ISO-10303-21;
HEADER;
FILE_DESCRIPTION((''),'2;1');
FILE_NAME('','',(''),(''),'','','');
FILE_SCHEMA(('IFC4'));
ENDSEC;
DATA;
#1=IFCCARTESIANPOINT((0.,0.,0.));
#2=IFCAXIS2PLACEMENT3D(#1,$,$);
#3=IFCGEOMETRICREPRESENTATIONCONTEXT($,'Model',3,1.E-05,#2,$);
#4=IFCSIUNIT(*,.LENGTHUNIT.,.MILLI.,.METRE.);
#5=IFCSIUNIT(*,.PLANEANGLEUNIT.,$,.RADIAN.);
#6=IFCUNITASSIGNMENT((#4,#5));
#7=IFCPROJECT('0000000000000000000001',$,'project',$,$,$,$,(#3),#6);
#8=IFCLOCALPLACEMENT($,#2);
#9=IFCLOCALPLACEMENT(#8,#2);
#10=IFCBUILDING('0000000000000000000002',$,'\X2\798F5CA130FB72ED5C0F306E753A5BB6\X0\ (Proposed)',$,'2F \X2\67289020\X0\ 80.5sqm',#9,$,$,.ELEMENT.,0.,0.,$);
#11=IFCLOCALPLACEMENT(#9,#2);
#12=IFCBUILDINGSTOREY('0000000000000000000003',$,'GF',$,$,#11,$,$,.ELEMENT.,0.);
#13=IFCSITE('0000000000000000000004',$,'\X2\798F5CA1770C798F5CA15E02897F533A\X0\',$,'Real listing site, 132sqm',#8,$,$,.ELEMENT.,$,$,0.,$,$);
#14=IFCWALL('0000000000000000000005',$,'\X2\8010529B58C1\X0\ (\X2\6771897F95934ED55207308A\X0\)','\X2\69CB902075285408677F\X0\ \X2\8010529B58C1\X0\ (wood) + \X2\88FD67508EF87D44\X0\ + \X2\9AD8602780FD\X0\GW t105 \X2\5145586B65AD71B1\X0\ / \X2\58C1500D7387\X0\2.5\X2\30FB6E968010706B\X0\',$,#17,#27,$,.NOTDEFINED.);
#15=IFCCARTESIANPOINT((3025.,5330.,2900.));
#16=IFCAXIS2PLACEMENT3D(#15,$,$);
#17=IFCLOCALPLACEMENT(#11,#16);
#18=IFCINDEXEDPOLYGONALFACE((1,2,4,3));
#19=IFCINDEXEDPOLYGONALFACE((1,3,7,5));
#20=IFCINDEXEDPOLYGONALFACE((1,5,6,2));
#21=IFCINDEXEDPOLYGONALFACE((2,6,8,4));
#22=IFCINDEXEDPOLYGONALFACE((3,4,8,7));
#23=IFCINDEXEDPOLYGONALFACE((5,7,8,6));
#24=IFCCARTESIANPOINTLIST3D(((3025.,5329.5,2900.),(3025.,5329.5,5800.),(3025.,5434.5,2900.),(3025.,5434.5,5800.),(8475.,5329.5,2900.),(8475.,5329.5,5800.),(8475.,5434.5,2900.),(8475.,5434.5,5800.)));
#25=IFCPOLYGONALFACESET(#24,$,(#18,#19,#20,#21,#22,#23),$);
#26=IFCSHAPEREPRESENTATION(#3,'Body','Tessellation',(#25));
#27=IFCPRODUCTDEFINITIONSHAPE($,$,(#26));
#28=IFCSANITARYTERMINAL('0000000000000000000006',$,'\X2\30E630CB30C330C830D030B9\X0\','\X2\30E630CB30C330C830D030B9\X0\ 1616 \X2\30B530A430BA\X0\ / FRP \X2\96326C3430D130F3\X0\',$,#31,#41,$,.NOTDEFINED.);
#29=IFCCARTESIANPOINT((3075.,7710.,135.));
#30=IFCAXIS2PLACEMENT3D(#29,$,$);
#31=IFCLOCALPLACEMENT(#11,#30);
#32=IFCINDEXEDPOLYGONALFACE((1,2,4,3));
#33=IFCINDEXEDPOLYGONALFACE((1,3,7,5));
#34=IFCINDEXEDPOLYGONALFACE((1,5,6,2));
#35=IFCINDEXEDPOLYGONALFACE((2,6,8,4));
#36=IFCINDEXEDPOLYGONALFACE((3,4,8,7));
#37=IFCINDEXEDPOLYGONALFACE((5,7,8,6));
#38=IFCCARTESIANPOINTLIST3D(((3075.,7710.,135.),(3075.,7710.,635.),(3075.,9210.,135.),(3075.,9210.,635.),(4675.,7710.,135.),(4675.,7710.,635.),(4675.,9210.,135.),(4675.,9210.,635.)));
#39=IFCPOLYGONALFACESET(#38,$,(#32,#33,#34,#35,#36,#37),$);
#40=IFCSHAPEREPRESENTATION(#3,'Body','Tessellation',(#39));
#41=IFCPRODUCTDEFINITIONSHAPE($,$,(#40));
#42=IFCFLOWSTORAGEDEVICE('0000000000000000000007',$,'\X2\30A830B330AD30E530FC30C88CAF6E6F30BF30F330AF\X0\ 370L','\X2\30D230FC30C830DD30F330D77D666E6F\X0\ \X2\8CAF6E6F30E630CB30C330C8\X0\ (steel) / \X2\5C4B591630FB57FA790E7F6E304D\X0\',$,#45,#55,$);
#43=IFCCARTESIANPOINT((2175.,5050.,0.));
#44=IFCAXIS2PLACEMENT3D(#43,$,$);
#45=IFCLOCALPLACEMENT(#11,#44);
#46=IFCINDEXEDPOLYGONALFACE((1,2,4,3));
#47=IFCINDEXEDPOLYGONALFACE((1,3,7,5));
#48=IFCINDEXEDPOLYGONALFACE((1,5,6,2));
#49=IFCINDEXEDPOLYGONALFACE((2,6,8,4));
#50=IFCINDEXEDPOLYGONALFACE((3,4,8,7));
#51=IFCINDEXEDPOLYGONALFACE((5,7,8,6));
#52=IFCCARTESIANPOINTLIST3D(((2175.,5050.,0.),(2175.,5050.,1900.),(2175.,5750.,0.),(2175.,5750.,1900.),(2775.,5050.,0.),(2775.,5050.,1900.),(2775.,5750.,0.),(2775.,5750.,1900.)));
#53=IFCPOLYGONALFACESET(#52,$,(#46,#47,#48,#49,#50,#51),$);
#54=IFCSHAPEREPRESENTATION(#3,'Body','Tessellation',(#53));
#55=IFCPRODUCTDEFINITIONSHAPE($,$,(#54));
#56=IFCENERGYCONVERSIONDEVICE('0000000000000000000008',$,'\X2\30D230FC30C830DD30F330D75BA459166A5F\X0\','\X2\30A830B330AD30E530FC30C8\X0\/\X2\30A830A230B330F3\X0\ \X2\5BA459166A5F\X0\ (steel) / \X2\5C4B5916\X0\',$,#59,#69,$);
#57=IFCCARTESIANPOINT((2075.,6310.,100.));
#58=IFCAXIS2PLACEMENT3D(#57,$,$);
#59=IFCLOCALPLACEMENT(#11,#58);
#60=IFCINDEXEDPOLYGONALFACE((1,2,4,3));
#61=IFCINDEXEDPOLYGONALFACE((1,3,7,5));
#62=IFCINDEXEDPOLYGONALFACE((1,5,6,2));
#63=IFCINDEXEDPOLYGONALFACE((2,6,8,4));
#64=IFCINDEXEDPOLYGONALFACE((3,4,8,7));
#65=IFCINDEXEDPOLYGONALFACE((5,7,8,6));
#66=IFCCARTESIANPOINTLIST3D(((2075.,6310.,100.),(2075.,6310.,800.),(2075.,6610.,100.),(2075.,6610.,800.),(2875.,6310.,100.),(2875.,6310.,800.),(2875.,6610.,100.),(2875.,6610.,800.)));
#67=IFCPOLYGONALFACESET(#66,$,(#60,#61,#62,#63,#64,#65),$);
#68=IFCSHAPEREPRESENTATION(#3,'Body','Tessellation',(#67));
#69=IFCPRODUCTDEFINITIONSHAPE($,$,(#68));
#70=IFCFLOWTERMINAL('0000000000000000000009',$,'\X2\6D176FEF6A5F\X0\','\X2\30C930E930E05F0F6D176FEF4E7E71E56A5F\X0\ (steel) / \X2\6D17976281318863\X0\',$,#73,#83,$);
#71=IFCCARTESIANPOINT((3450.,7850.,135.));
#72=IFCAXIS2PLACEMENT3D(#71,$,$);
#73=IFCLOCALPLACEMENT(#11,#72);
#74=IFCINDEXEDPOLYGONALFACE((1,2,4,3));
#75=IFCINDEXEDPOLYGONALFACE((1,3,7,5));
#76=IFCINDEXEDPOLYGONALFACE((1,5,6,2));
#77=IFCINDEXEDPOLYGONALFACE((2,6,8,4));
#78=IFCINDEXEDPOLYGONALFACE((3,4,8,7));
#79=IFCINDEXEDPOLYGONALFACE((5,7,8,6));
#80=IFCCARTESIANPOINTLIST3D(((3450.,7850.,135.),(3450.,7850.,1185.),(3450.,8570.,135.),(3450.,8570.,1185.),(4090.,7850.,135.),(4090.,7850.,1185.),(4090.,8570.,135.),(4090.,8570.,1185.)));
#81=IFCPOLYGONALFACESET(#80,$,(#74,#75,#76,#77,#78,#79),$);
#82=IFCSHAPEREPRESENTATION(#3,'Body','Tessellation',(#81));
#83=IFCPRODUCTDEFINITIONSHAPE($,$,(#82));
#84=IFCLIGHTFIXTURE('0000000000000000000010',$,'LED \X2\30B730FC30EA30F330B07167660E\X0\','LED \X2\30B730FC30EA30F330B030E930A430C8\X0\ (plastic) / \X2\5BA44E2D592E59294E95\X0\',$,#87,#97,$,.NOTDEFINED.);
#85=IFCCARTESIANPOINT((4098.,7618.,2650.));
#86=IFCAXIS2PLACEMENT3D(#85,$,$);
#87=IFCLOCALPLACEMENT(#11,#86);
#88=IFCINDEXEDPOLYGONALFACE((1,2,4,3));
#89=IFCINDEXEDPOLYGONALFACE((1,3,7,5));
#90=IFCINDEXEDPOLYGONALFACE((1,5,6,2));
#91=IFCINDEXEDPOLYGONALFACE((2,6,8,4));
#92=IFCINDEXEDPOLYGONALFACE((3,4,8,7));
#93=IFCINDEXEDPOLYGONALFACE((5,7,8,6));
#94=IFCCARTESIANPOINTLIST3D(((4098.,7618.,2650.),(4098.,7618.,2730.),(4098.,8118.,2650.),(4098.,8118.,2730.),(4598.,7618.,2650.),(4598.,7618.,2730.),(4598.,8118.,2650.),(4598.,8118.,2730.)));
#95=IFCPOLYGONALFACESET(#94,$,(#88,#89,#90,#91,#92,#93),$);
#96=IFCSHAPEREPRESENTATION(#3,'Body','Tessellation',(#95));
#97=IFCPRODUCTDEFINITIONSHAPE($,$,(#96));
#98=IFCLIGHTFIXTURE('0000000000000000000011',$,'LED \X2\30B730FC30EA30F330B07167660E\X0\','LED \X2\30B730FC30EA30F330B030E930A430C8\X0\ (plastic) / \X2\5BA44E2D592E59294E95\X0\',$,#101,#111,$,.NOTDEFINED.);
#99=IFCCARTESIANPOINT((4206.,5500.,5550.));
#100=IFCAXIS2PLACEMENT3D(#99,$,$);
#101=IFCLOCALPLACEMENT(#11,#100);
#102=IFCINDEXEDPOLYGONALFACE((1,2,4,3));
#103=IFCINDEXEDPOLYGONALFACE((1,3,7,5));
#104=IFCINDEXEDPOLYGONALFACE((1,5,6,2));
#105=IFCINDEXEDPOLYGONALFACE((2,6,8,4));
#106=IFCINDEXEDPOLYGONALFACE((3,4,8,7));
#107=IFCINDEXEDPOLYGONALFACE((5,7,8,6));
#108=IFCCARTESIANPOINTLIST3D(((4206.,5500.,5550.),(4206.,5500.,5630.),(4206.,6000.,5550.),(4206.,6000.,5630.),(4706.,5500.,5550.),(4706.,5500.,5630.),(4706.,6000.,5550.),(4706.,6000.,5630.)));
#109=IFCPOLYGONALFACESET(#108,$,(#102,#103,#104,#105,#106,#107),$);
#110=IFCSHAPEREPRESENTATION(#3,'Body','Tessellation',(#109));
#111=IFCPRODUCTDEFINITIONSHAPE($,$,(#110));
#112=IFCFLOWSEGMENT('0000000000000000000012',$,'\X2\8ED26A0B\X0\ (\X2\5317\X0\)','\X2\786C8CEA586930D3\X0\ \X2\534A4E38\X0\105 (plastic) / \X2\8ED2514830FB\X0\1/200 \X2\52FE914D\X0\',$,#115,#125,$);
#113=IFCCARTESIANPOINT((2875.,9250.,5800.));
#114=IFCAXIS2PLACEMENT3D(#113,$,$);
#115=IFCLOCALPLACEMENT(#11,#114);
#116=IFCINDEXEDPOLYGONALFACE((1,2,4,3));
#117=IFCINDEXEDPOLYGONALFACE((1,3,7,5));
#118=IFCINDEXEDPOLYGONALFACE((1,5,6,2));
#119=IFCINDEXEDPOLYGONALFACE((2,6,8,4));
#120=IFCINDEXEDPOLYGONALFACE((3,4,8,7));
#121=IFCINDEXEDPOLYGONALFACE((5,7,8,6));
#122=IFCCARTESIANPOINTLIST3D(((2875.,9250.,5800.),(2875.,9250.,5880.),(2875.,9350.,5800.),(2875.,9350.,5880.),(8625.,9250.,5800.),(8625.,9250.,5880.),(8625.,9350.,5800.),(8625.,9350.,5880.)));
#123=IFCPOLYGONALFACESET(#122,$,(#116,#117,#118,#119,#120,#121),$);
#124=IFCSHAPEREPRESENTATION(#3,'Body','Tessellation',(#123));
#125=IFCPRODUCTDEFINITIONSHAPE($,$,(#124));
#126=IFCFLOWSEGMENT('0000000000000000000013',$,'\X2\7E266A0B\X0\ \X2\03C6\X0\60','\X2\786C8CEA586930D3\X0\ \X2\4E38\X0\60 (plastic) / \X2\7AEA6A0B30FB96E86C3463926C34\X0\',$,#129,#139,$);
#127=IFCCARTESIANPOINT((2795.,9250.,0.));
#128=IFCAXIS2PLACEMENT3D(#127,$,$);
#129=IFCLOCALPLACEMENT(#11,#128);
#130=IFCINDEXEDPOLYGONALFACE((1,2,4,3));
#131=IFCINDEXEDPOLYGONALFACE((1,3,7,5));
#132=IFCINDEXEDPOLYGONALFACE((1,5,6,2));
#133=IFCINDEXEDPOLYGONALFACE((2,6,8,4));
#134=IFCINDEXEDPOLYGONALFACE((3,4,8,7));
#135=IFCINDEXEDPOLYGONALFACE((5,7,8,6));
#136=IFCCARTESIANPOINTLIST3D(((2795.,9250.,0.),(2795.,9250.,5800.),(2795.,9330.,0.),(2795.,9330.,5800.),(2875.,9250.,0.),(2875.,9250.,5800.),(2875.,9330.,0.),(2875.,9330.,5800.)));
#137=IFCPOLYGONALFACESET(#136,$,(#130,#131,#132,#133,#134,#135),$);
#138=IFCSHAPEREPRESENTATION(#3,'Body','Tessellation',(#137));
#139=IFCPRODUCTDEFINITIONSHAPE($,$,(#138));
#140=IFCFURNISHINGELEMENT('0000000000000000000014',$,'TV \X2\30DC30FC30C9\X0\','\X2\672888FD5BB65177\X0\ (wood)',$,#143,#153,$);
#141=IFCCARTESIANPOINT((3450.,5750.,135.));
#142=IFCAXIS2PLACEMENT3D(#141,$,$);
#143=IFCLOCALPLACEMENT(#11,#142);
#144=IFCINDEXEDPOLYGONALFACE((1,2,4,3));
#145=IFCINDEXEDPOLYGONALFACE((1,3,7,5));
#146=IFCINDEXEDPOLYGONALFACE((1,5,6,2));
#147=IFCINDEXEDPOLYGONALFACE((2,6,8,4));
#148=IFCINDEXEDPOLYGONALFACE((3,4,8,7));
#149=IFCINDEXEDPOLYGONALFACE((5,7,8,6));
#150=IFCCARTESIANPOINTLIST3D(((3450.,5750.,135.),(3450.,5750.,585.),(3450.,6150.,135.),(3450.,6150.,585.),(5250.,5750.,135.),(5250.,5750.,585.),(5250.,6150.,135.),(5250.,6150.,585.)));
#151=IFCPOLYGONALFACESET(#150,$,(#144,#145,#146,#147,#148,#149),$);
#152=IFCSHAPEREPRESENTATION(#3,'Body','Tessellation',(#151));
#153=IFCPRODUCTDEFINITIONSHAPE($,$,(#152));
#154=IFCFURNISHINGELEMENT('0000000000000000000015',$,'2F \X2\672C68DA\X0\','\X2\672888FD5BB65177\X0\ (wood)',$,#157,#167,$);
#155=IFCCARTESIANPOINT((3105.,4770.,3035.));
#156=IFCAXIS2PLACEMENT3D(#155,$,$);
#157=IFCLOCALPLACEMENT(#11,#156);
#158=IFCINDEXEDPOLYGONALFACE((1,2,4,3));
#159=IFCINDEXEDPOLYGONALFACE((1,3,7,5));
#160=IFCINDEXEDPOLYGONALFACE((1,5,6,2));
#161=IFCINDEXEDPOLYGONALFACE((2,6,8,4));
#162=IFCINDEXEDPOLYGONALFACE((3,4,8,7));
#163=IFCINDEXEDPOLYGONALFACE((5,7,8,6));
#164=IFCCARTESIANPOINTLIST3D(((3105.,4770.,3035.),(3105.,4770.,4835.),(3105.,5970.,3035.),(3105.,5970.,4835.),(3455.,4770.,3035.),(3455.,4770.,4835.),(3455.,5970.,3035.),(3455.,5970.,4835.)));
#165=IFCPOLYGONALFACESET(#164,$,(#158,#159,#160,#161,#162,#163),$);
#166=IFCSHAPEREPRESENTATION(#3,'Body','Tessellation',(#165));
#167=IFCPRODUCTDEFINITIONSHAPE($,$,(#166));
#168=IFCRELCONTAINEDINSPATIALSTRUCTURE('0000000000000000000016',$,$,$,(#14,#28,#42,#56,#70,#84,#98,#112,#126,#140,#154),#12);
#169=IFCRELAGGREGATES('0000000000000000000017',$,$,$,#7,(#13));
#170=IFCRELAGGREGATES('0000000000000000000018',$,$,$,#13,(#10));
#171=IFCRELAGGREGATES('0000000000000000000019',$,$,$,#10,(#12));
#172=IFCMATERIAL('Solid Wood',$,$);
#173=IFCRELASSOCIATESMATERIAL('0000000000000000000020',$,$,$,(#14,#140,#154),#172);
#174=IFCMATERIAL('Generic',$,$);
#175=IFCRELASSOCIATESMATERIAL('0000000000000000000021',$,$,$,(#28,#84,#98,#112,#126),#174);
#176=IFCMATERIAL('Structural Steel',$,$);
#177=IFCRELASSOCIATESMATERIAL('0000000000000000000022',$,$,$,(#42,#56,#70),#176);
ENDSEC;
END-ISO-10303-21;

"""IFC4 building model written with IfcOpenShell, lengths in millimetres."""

from ifc_helpers import new_model, si_unit, frame, frame_2d, origin, place, context, project, spatial, rectangle, extrude, material, element, save


model = new_model("IFC4")

# Units and contexts
model_context = context("Model", 3, precision=1e-05, world=origin())
ifc_project = project(units=[si_unit("LENGTHUNIT", "METRE", prefix="MILLI"), si_unit("PLANEANGLEUNIT", "RADIAN")], contexts=[model_context])

# Site, building, storey
site_placement = place(None, origin())
site = spatial("IfcSite", under=ifc_project, at=site_placement, Name="福岡県福岡市西区", ObjectType="Real listing site, 132sqm", CompositionType="ELEMENT", RefElevation=0.0)
building_placement = place(site_placement, origin())
building = spatial("IfcBuilding", under=site, at=building_placement, Name="福岡・狭小の町家 (Proposed)", ObjectType="2F 木造 80.5sqm", CompositionType="ELEMENT", ElevationOfRefHeight=0.0, ElevationOfTerrain=0.0)
storey_placement = place(building_placement, origin())
storey = spatial("IfcBuildingStorey", under=building, at=storey_placement, Name="GF", CompositionType="ELEMENT", Elevation=0.0)

# Shared definitions
ifc_material_1 = material(Name="Solid Wood")

# Wall
wall_1_placement = place(storey_placement, frame((3025.0, 5330.0, 2900.0)))
element("IfcWall", 1, at=wall_1_placement, inside=storey, material=ifc_material_1, Name="耐力壁 (東西間仕切り)", Description="構造用合板 耐力壁 (wood) + 製材軸組 + 高性能GW t105 充填断熱 / 壁倍率2.5・準耐火", PredefinedType="NOTDEFINED", context=model_context, shape_type="SweptSolid", body=[
    extrude(rectangle(XDim=5450.0, YDim=105.0, at=frame_2d((2725.0, 52.0))), frame((3025.0, 5330.0, 2900.0)), (0.0, 0.0, 1.0), 2900.0),
])

# Sanitary terminal
ifc_material_2 = material(Name="Generic")
sanitary_terminal_placement = place(storey_placement, frame((3075.0, 7710.0, 135.0)))
element("IfcSanitaryTerminal", 2, at=sanitary_terminal_placement, inside=storey, material=ifc_material_2, Name="ユニットバス", Description="ユニットバス 1616 サイズ / FRP 防水パン", PredefinedType="NOTDEFINED", context=model_context, shape_type="SweptSolid", body=[
    extrude(rectangle(XDim=1600.0, YDim=1500.0, at=frame_2d((800.0, 750.0))), frame((3075.0, 7710.0, 135.0)), (0.0, 0.0, 1.0), 500.0),
])

# Flow storage device
ifc_material_3 = material(Name="Structural Steel")
flow_storage_device_placement = place(storey_placement, frame((2175.0, 5050.0, 0.0)))
element("IfcFlowStorageDevice", 3, at=flow_storage_device_placement, inside=storey, material=ifc_material_3, Name="エコキュート貯湯タンク 370L", Description="ヒートポンプ給湯 貯湯ユニット (steel) / 屋外・基礎置き", context=model_context, shape_type="SweptSolid", body=[
    extrude(rectangle(XDim=600.0, YDim=700.0, at=frame_2d((300.0, 350.0))), frame((2175.0, 5050.0, 0.0)), (0.0, 0.0, 1.0), 1900.0),
])

# Energy conversion device
energy_conversion_device_placement = place(storey_placement, frame((2075.0, 6310.0, 100.0)))
element("IfcEnergyConversionDevice", 4, at=energy_conversion_device_placement, inside=storey, material=ifc_material_3, Name="ヒートポンプ室外機", Description="エコキュート/エアコン 室外機 (steel) / 屋外", context=model_context, shape_type="SweptSolid", body=[
    extrude(rectangle(XDim=800.0, YDim=300.0, at=frame_2d((400.0, 150.0))), frame((2075.0, 6310.0, 100.0)), (0.0, 0.0, 1.0), 700.0),
])

# Flow terminal
flow_terminal_placement = place(storey_placement, frame((3450.0, 7850.0, 135.0)))
element("IfcFlowTerminal", 5, at=flow_terminal_placement, inside=storey, material=ifc_material_3, Name="洗濯機", Description="ドラム式洗濯乾燥機 (steel) / 洗面脱衣", context=model_context, shape_type="SweptSolid", body=[
    extrude(rectangle(XDim=640.0, YDim=720.0, at=frame_2d((320.0, 360.0))), frame((3450.0, 7850.0, 135.0)), (0.0, 0.0, 1.0), 1050.0),
])

# Light fixtures
light_fixture_1_placement = place(storey_placement, frame((4098.0, 7618.0, 2650.0)))
element("IfcLightFixture", 6, at=light_fixture_1_placement, inside=storey, material=ifc_material_2, Name="LED シーリング照明", Description="LED シーリングライト (plastic) / 室中央天井", PredefinedType="NOTDEFINED", context=model_context, shape_type="SweptSolid", body=[
    extrude(rectangle(XDim=500.0, YDim=500.0, at=frame_2d((250.0, 250.0))), frame((4098.0, 7618.0, 2650.0)), (0.0, 0.0, 1.0), 80.0),
])
light_fixture_2_placement = place(storey_placement, frame((4206.0, 5500.0, 5550.0)))
element("IfcLightFixture", 7, at=light_fixture_2_placement, inside=storey, material=ifc_material_2, Name="LED シーリング照明", Description="LED シーリングライト (plastic) / 室中央天井", PredefinedType="NOTDEFINED", context=model_context, shape_type="SweptSolid", body=[
    extrude(rectangle(XDim=500.0, YDim=500.0, at=frame_2d((250.0, 250.0))), frame((4206.0, 5500.0, 5550.0)), (0.0, 0.0, 1.0), 80.0),
])

# Flow segments
flow_segment_1_placement = place(storey_placement, frame((2875.0, 9250.0, 5800.0)))
element("IfcFlowSegment", 8, at=flow_segment_1_placement, inside=storey, material=ifc_material_2, Name="軒樋 (北)", Description="硬質塩ビ 半丸105 (plastic) / 軒先・1/200 勾配", context=model_context, shape_type="SweptSolid", body=[
    extrude(rectangle(XDim=5750.0, YDim=100.0, at=frame_2d((2875.0, 50.0))), frame((2875.0, 9250.0, 5800.0)), (0.0, 0.0, 1.0), 80.0),
])
flow_segment_2_placement = place(storey_placement, frame((2795.0, 9250.0, 0.0)))
element("IfcFlowSegment", 9, at=flow_segment_2_placement, inside=storey, material=ifc_material_2, Name="縦樋 φ60", Description="硬質塩ビ 丸60 (plastic) / 竪樋・雨水排水", context=model_context, shape_type="SweptSolid", body=[
    extrude(rectangle(XDim=80.0, YDim=80.0, at=frame_2d((40.0, 40.0))), frame((2795.0, 9250.0, 0.0)), (0.0, 0.0, 1.0), 5800.0),
])

# Furnishing elements
furnishing_1_placement = place(storey_placement, frame((3450.0, 5750.0, 135.0)))
element("IfcFurnishingElement", 10, at=furnishing_1_placement, inside=storey, material=ifc_material_1, Name="TV ボード", Description="木製家具 (wood)", context=model_context, shape_type="SweptSolid", body=[
    extrude(rectangle(XDim=1800.0, YDim=400.0, at=frame_2d((900.0, 200.0))), frame((3450.0, 5750.0, 135.0)), (0.0, 0.0, 1.0), 450.0),
])
furnishing_2_placement = place(storey_placement, frame((3105.0, 4770.0, 3035.0)))
element("IfcFurnishingElement", 11, at=furnishing_2_placement, inside=storey, material=ifc_material_1, Name="2F 本棚", Description="木製家具 (wood)", context=model_context, shape_type="SweptSolid", body=[
    extrude(rectangle(XDim=350.0, YDim=1200.0, at=frame_2d((175.0, 600.0))), frame((3105.0, 4770.0, 3035.0)), (0.0, 0.0, 1.0), 1800.0),
])

save(model, "model.ifc")
